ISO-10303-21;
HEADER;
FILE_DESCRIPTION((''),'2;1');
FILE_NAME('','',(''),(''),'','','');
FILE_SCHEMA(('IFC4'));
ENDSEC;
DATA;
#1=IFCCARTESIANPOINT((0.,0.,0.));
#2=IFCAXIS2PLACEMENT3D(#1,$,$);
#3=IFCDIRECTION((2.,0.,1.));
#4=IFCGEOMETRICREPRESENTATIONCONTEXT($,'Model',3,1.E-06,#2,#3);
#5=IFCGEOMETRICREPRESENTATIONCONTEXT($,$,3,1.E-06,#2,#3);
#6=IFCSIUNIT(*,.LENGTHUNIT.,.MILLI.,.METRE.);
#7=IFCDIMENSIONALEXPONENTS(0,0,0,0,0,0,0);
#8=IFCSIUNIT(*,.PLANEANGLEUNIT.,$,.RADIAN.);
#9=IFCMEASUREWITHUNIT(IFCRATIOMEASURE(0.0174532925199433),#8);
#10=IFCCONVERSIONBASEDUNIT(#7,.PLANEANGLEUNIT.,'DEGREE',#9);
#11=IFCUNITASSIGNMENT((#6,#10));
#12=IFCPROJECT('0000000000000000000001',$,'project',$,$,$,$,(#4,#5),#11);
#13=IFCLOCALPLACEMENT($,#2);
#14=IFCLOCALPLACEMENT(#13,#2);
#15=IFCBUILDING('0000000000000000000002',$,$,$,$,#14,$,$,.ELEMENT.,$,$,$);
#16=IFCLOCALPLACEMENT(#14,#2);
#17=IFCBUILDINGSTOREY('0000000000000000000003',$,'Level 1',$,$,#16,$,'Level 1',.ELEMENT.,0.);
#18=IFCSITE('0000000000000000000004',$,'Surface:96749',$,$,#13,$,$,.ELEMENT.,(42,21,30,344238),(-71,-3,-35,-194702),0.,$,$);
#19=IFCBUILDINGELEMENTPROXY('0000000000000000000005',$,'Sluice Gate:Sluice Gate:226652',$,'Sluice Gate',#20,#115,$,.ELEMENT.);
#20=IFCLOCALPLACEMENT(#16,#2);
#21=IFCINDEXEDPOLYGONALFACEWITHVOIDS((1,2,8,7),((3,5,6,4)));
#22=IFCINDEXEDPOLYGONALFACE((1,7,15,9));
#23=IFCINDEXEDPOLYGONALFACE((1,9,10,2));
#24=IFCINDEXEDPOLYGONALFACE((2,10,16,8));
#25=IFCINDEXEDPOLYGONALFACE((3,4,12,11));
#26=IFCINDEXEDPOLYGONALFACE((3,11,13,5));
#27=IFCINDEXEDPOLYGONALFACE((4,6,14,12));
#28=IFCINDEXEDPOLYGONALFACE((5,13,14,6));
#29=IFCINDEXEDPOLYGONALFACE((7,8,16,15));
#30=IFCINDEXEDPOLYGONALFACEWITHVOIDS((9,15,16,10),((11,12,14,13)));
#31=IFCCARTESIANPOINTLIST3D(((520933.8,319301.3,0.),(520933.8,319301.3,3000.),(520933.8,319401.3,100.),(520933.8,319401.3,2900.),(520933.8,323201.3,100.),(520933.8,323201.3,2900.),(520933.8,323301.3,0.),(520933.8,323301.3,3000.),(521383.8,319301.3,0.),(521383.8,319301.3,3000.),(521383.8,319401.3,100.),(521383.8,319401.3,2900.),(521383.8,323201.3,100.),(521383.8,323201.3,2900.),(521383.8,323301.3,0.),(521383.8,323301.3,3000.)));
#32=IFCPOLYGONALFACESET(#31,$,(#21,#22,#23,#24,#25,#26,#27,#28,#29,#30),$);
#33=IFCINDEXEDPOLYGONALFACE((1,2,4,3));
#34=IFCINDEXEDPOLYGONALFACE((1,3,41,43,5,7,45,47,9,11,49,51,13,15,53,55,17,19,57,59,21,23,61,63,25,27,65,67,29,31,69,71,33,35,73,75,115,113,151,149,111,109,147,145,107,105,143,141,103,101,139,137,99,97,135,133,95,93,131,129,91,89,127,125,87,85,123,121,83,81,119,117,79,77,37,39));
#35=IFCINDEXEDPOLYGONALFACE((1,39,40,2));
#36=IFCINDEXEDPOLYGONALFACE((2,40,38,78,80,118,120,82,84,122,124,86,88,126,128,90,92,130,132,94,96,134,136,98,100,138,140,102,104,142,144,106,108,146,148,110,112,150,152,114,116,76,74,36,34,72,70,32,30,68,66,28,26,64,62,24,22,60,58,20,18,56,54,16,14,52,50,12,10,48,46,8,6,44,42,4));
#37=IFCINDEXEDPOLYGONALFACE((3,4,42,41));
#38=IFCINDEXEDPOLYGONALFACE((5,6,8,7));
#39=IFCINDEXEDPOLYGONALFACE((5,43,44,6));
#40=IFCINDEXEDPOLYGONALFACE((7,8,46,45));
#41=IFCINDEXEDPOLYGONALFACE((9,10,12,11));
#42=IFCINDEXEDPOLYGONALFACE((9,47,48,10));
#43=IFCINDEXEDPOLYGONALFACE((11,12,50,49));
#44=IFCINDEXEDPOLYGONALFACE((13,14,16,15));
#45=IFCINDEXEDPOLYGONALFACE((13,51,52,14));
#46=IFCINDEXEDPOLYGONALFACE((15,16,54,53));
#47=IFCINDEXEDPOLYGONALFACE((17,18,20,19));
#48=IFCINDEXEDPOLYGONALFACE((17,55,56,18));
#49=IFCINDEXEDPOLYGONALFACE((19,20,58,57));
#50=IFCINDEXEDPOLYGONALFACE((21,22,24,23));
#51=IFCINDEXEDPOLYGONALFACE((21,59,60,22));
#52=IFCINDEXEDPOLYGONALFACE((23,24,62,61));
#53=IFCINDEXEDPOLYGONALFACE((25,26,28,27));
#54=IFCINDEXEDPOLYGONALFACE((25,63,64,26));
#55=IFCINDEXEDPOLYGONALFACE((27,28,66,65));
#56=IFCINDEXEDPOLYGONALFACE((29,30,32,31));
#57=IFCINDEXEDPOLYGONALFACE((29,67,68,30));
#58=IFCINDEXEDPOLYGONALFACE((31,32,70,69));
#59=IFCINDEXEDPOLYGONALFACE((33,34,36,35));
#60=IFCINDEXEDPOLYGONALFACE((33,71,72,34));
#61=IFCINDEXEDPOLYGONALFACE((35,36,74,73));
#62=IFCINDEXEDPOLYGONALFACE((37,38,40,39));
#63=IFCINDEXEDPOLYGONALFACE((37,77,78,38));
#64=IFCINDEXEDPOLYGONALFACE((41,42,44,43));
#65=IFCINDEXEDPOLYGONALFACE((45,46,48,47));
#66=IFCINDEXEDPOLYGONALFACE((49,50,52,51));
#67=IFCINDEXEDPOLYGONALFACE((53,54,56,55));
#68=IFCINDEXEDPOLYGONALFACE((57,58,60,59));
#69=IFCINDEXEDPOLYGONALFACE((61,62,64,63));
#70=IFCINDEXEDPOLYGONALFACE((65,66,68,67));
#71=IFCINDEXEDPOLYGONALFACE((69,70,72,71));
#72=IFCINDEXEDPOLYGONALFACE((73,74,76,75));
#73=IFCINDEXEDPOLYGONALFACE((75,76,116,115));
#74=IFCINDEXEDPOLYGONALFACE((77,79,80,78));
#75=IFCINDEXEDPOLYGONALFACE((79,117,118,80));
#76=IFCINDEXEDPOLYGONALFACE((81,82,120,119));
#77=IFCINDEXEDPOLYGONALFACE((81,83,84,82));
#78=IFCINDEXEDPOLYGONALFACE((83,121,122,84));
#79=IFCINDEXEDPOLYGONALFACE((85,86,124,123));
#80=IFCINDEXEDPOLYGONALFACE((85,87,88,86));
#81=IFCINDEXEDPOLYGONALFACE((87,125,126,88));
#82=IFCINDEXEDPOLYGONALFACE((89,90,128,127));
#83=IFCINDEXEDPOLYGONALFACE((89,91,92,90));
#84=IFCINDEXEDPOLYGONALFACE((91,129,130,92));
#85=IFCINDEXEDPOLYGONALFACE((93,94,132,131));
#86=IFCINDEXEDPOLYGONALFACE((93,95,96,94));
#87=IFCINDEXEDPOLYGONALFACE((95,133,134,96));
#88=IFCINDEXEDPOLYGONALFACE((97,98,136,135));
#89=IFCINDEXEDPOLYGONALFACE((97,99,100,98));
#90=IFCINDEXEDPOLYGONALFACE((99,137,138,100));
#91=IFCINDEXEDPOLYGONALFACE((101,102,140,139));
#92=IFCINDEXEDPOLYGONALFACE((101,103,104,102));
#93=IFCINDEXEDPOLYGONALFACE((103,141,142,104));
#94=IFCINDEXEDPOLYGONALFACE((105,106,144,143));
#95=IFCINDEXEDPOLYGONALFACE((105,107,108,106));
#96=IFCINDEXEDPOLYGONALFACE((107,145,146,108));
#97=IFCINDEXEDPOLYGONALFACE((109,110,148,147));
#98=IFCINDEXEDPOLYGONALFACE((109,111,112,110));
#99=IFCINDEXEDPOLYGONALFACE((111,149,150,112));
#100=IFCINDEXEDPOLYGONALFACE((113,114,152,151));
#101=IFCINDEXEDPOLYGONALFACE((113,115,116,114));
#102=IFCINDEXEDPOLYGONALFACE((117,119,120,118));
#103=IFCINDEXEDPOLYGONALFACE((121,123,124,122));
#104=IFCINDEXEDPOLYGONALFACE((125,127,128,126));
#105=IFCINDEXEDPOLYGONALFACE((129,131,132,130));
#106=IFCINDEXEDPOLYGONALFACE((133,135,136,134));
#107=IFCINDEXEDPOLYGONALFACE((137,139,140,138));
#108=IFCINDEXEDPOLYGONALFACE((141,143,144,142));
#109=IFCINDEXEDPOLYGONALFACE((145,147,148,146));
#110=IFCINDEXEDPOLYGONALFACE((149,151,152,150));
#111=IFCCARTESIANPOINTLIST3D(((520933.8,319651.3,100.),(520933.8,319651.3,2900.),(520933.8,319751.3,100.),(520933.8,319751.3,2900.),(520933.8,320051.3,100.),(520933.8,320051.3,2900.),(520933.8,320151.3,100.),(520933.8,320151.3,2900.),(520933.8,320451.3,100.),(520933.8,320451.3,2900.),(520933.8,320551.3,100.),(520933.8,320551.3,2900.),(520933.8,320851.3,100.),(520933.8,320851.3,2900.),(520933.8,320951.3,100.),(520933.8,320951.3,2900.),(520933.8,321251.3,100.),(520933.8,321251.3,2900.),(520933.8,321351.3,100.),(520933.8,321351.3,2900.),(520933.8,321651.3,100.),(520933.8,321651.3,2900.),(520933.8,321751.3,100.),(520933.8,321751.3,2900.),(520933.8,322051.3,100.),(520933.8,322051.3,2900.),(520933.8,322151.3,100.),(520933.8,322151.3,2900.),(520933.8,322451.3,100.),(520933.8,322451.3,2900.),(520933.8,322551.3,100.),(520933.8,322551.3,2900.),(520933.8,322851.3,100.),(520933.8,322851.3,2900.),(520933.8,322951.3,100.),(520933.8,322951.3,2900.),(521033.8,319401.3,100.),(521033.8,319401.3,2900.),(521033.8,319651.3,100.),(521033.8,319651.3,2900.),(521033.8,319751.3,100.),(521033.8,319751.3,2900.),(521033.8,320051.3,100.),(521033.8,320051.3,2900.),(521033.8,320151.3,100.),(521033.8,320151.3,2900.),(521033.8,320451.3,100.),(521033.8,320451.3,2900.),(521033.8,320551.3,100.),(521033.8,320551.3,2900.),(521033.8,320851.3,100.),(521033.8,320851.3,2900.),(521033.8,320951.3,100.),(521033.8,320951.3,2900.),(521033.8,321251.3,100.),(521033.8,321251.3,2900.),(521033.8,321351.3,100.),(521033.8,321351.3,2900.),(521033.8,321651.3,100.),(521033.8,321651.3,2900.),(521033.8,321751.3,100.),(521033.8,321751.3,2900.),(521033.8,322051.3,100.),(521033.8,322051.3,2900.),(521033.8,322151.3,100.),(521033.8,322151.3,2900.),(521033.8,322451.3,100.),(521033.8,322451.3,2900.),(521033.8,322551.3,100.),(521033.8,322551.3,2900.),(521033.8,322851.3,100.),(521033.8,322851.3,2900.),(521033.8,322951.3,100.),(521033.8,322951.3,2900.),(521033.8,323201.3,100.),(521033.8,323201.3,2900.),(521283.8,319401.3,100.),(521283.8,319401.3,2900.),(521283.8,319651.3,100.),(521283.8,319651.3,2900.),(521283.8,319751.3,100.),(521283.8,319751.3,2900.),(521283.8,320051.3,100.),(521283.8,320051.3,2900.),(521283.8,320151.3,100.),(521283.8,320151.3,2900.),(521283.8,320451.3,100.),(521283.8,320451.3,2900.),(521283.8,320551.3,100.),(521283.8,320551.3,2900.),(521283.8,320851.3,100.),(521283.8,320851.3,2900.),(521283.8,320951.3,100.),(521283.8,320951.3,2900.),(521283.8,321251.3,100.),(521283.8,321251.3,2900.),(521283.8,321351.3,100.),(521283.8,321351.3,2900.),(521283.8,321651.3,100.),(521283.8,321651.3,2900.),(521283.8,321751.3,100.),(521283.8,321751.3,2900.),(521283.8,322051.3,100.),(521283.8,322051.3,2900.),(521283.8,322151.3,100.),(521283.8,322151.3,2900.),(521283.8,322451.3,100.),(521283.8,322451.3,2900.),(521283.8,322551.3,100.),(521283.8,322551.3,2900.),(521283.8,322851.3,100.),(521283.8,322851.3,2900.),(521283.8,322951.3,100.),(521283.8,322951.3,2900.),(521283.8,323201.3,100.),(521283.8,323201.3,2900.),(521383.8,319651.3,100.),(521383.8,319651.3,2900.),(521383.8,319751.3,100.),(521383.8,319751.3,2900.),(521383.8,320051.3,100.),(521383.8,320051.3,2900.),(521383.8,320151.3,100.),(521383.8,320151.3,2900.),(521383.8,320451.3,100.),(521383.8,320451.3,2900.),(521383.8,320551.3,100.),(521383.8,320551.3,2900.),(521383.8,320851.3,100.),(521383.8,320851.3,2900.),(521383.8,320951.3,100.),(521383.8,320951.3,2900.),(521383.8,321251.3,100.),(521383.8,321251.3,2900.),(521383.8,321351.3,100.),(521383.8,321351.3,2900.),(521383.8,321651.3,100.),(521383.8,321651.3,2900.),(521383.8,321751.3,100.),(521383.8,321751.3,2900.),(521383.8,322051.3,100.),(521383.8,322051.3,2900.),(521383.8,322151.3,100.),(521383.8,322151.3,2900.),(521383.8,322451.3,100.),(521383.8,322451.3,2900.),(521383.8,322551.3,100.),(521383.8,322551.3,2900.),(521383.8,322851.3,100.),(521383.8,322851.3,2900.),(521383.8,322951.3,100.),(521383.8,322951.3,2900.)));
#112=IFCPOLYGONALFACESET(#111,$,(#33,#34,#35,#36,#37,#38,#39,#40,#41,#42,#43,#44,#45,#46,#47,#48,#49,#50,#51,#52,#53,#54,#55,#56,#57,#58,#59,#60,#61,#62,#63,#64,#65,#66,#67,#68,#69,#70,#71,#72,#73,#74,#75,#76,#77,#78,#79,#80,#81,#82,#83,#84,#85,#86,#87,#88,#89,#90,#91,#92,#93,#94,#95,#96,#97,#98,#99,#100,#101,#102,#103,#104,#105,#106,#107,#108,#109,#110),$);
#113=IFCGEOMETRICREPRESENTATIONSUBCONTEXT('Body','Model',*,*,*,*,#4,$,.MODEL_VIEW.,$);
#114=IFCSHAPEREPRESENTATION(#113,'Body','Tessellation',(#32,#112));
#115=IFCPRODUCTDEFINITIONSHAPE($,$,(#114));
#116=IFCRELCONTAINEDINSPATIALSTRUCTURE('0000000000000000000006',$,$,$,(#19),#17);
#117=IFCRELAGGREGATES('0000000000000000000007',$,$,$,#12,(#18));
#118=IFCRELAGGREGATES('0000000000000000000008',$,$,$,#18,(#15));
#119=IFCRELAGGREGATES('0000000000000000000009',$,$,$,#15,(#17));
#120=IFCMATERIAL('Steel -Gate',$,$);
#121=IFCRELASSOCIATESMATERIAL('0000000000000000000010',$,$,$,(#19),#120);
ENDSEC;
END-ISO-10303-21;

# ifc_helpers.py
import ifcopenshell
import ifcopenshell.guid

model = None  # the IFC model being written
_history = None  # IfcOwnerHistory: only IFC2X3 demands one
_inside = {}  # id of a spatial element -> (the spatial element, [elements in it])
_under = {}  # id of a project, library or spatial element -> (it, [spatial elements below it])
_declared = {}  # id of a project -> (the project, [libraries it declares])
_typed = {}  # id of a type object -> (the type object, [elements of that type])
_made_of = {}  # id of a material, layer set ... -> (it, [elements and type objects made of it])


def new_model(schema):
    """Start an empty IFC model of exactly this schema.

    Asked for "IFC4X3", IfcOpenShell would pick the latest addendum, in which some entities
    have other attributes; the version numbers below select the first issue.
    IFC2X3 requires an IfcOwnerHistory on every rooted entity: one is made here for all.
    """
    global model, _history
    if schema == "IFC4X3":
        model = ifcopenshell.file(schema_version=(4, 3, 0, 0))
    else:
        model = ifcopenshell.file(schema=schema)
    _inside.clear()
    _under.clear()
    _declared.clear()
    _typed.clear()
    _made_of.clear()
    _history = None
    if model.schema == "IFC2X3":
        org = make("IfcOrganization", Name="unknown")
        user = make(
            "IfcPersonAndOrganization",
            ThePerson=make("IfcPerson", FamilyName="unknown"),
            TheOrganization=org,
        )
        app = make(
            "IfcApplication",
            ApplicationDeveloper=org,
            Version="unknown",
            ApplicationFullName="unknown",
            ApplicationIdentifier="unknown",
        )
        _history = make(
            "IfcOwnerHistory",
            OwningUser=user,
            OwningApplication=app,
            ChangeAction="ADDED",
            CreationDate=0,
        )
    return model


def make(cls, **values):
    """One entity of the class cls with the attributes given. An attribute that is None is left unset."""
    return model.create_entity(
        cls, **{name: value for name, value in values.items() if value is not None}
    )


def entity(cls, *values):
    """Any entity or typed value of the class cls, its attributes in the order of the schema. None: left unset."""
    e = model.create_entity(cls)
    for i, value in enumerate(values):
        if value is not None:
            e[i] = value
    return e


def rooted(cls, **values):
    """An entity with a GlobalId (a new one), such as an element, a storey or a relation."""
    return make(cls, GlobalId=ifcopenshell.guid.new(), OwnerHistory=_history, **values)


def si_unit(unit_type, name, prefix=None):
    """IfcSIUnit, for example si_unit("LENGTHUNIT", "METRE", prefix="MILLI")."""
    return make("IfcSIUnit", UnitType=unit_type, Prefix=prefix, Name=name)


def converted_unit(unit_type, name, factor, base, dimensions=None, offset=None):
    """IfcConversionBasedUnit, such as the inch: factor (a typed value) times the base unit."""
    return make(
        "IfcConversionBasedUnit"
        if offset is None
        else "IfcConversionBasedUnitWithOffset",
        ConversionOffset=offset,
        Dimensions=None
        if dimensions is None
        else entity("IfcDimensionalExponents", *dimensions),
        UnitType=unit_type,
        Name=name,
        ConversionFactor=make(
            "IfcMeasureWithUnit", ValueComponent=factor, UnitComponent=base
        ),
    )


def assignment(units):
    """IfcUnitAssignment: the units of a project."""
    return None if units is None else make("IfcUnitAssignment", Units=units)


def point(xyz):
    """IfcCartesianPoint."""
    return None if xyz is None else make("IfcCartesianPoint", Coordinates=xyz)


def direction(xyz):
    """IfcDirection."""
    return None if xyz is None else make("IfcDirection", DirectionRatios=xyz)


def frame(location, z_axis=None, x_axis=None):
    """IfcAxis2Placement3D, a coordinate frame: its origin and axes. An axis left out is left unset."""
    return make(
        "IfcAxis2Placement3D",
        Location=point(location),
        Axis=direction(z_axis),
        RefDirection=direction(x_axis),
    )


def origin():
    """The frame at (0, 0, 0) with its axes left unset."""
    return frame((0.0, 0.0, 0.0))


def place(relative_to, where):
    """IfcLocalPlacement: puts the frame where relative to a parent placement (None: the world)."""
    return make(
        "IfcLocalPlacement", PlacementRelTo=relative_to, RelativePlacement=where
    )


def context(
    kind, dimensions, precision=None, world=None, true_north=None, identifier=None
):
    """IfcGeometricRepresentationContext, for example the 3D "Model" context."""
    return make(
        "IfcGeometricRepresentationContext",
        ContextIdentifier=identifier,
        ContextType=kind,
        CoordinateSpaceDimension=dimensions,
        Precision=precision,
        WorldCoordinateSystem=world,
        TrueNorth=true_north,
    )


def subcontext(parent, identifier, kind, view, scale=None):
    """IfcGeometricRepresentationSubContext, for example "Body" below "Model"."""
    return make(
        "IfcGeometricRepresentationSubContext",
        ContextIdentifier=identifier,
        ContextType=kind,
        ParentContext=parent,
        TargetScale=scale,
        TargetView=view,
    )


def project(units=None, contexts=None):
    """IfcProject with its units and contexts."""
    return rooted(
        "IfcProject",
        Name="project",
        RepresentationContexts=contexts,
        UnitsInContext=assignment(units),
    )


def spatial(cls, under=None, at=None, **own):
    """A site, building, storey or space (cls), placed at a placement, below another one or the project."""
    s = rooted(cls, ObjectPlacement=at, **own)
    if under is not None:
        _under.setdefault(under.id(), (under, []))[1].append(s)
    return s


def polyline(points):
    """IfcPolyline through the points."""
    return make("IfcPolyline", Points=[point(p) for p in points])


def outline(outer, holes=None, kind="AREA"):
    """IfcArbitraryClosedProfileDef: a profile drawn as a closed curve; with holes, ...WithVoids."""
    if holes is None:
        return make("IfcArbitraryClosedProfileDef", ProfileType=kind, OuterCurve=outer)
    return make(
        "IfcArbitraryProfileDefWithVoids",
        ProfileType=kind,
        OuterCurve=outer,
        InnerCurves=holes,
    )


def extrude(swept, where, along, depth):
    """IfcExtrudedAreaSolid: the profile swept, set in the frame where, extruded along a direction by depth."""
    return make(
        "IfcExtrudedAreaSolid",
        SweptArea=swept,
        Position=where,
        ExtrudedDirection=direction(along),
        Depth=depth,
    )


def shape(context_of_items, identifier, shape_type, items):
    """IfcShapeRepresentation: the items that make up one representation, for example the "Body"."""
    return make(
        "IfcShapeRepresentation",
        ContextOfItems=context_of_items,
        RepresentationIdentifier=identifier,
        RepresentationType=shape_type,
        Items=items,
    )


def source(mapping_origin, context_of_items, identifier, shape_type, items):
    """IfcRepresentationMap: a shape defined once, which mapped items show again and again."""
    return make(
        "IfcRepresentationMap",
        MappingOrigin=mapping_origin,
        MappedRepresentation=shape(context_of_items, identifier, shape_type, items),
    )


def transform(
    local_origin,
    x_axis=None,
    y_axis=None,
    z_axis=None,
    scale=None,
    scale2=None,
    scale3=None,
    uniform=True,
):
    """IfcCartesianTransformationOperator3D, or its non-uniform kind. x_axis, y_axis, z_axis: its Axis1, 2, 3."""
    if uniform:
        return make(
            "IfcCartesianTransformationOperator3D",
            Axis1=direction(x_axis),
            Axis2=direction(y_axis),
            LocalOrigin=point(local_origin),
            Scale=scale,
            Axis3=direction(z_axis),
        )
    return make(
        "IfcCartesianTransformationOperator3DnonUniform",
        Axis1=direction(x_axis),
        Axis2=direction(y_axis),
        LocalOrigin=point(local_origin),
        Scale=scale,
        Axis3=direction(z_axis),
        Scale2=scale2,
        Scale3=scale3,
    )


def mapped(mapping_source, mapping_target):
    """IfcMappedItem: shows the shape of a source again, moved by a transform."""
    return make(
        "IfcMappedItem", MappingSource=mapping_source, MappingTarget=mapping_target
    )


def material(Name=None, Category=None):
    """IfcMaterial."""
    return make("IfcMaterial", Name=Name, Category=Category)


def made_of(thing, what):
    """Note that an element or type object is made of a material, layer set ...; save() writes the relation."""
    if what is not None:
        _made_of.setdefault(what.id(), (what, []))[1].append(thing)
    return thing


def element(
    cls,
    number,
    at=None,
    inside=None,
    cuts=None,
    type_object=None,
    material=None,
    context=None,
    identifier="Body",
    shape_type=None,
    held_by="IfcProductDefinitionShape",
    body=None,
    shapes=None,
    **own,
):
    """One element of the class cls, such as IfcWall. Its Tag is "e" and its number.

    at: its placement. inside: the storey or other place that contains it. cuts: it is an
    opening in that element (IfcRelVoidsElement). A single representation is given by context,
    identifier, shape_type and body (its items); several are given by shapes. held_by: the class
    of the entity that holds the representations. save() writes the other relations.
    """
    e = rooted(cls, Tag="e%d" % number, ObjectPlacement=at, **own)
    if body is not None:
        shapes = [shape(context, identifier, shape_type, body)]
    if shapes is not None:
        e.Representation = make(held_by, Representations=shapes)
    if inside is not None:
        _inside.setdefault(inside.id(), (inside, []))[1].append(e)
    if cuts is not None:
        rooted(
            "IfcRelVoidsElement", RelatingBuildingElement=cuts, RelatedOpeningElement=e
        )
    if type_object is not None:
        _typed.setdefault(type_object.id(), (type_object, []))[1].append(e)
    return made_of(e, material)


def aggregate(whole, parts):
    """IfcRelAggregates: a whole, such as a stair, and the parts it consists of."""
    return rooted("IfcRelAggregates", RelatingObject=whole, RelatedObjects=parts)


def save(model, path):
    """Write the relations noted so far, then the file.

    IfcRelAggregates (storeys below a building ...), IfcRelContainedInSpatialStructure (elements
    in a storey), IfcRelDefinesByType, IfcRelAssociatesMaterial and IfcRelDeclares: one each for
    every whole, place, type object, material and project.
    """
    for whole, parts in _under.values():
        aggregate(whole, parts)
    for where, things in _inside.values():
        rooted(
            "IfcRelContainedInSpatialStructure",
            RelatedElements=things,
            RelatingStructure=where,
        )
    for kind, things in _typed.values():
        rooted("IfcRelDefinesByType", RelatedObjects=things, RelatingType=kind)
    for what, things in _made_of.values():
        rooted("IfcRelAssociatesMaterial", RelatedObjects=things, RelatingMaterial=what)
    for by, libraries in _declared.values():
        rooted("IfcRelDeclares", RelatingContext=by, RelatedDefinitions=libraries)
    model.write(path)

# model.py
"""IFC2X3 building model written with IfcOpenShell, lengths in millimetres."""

from ifc_helpers import new_model, entity, si_unit, converted_unit, direction, frame, origin, place, context, subcontext, project, spatial, polyline, outline, extrude, source, transform, mapped, material, element, save


model = new_model("IFC2X3")

# Units and contexts
model_context = context("Model", 3, precision=1e-06, world=origin(), true_north=direction((2.0, 0.0, 1.0)))
context_of_model = context(None, 3, precision=1e-06, world=origin(), true_north=direction((2.0, 0.0, 1.0)))
body_context = subcontext(model_context, "Body", "Model", "MODEL_VIEW")
ifc_project = project(units=[si_unit("LENGTHUNIT", "METRE", prefix="MILLI"), converted_unit("PLANEANGLEUNIT", "DEGREE", entity("IfcRatioMeasure", 0.0174532925199433), si_unit("PLANEANGLEUNIT", "RADIAN"), dimensions=[0, 0, 0, 0, 0, 0, 0])], contexts=[model_context, context_of_model])

# Site, building, storey
site_placement = place(None, origin())
site = spatial("IfcSite", under=ifc_project, at=site_placement, Name="Surface:96749", CompositionType="ELEMENT", RefLatitude=(42, 21, 30, 344238), RefLongitude=(-71, -3, -35, -194702), RefElevation=0.0)
building_placement = place(site_placement, origin())
building = spatial("IfcBuilding", under=site, at=building_placement, CompositionType="ELEMENT")
storey_placement = place(building_placement, origin())
storey = spatial("IfcBuildingStorey", under=building, at=storey_placement, Name="Level 1", LongName="Level 1", CompositionType="ELEMENT", Elevation=0.0)

# Building element proxy
ifc_material = material(Name="Steel -Gate")
shared_shape_1 = source(origin(), body_context, "Body", "SweptSolid", [
    extrude(outline(polyline([(-1500.0, -2000.0), (1500.0, -2000.0), (1500.0, 2000.0), (-1500.0, 2000.0), (-1500.0, -2000.0)]), holes=[polyline([(1400.0, -1900.0), (-1400.0, -1900.0), (-1400.0, 1900.0), (1400.0, 1900.0), (1400.0, -1900.0)])]), frame((0.0, -225.0, 1500.0), z_axis=(0.0, 1.0, 0.0), x_axis=(0.0, 0.0, -1.0)), (0.0, 0.0, 1.0), 450.0),
    extrude(outline(polyline([(1650.0, -125.0), (1900.0, -125.0), (1900.0, 125.0), (1650.0, 125.0), (1650.0, 225.0), (1550.0, 225.0), (1550.0, 125.0), (1250.0, 125.0), (1250.0, 225.0), (1150.0, 225.0), (1150.0, 125.0), (850.0, 125.0), (850.0, 225.0), (750.0, 225.0), (750.0, 125.0), (450.0, 125.0), (450.0, 225.0), (350.0, 225.0), (350.0, 125.0), (50.0, 125.0), (50.0, 225.0), (-50.0, 225.0), (-50.0, 125.0), (-350.0, 125.0), (-350.0, 225.0), (-450.0, 225.0), (-450.0, 125.0), (-750.0, 125.0), (-750.0, 225.0), (-850.0, 225.0), (-850.0, 125.0), (-1150.0, 125.0), (-1150.0, 225.0), (-1250.0, 225.0), (-1250.0, 125.0), (-1550.0, 125.0), (-1550.0, 225.0), (-1650.0, 225.0), (-1650.0, 125.0), (-1900.0, 125.0), (-1900.0, -125.0), (-1650.0, -125.0), (-1650.0, -225.0), (-1550.0, -225.0), (-1550.0, -125.0), (-1250.0, -125.0), (-1250.0, -225.0), (-1150.0, -225.0), (-1150.0, -125.0), (-850.0, -125.0), (-850.0, -225.0), (-750.0, -225.0), (-750.0, -125.0), (-450.0, -125.0), (-450.0, -225.0), (-350.0, -225.0), (-350.0, -125.0), (-50.0, -125.0), (-50.0, -225.0), (50.0, -225.0), (50.0, -125.0), (350.0, -125.0), (350.0, -225.0), (450.0, -225.0), (450.0, -125.0), (750.0, -125.0), (750.0, -225.0), (850.0, -225.0), (850.0, -125.0), (1150.0, -125.0), (1150.0, -225.0), (1250.0, -225.0), (1250.0, -125.0), (1550.0, -125.0), (1550.0, -225.0), (1650.0, -225.0), (1650.0, -125.0)])), frame((0.0, 0.0, 100.0), z_axis=(0.0, 0.0, 1.0), x_axis=(-1.0, 0.0, 0.0)), (0.0, 0.0, 1.0), 2800.0),
])
for number, where, z_axis, x_axis, name in (
    (1, (521158.8, 321301.3, 0.0), (0.0, 0.0, 1.0), (0.0, 1.0, 0.0), "Sluice Gate:Sluice Gate:226652"),
):
    element("IfcBuildingElementProxy", number, at=place(storey_placement, frame(where, z_axis=z_axis, x_axis=x_axis)), inside=storey, material=ifc_material, Name=name, ObjectType="Sluice Gate", CompositionType="ELEMENT", context=body_context, shape_type="MappedRepresentation", body=[
        mapped(shared_shape_1, transform((0.0, 0.0, 0.0), scale=1.0)),
    ])

save(model, "model.ifc")
